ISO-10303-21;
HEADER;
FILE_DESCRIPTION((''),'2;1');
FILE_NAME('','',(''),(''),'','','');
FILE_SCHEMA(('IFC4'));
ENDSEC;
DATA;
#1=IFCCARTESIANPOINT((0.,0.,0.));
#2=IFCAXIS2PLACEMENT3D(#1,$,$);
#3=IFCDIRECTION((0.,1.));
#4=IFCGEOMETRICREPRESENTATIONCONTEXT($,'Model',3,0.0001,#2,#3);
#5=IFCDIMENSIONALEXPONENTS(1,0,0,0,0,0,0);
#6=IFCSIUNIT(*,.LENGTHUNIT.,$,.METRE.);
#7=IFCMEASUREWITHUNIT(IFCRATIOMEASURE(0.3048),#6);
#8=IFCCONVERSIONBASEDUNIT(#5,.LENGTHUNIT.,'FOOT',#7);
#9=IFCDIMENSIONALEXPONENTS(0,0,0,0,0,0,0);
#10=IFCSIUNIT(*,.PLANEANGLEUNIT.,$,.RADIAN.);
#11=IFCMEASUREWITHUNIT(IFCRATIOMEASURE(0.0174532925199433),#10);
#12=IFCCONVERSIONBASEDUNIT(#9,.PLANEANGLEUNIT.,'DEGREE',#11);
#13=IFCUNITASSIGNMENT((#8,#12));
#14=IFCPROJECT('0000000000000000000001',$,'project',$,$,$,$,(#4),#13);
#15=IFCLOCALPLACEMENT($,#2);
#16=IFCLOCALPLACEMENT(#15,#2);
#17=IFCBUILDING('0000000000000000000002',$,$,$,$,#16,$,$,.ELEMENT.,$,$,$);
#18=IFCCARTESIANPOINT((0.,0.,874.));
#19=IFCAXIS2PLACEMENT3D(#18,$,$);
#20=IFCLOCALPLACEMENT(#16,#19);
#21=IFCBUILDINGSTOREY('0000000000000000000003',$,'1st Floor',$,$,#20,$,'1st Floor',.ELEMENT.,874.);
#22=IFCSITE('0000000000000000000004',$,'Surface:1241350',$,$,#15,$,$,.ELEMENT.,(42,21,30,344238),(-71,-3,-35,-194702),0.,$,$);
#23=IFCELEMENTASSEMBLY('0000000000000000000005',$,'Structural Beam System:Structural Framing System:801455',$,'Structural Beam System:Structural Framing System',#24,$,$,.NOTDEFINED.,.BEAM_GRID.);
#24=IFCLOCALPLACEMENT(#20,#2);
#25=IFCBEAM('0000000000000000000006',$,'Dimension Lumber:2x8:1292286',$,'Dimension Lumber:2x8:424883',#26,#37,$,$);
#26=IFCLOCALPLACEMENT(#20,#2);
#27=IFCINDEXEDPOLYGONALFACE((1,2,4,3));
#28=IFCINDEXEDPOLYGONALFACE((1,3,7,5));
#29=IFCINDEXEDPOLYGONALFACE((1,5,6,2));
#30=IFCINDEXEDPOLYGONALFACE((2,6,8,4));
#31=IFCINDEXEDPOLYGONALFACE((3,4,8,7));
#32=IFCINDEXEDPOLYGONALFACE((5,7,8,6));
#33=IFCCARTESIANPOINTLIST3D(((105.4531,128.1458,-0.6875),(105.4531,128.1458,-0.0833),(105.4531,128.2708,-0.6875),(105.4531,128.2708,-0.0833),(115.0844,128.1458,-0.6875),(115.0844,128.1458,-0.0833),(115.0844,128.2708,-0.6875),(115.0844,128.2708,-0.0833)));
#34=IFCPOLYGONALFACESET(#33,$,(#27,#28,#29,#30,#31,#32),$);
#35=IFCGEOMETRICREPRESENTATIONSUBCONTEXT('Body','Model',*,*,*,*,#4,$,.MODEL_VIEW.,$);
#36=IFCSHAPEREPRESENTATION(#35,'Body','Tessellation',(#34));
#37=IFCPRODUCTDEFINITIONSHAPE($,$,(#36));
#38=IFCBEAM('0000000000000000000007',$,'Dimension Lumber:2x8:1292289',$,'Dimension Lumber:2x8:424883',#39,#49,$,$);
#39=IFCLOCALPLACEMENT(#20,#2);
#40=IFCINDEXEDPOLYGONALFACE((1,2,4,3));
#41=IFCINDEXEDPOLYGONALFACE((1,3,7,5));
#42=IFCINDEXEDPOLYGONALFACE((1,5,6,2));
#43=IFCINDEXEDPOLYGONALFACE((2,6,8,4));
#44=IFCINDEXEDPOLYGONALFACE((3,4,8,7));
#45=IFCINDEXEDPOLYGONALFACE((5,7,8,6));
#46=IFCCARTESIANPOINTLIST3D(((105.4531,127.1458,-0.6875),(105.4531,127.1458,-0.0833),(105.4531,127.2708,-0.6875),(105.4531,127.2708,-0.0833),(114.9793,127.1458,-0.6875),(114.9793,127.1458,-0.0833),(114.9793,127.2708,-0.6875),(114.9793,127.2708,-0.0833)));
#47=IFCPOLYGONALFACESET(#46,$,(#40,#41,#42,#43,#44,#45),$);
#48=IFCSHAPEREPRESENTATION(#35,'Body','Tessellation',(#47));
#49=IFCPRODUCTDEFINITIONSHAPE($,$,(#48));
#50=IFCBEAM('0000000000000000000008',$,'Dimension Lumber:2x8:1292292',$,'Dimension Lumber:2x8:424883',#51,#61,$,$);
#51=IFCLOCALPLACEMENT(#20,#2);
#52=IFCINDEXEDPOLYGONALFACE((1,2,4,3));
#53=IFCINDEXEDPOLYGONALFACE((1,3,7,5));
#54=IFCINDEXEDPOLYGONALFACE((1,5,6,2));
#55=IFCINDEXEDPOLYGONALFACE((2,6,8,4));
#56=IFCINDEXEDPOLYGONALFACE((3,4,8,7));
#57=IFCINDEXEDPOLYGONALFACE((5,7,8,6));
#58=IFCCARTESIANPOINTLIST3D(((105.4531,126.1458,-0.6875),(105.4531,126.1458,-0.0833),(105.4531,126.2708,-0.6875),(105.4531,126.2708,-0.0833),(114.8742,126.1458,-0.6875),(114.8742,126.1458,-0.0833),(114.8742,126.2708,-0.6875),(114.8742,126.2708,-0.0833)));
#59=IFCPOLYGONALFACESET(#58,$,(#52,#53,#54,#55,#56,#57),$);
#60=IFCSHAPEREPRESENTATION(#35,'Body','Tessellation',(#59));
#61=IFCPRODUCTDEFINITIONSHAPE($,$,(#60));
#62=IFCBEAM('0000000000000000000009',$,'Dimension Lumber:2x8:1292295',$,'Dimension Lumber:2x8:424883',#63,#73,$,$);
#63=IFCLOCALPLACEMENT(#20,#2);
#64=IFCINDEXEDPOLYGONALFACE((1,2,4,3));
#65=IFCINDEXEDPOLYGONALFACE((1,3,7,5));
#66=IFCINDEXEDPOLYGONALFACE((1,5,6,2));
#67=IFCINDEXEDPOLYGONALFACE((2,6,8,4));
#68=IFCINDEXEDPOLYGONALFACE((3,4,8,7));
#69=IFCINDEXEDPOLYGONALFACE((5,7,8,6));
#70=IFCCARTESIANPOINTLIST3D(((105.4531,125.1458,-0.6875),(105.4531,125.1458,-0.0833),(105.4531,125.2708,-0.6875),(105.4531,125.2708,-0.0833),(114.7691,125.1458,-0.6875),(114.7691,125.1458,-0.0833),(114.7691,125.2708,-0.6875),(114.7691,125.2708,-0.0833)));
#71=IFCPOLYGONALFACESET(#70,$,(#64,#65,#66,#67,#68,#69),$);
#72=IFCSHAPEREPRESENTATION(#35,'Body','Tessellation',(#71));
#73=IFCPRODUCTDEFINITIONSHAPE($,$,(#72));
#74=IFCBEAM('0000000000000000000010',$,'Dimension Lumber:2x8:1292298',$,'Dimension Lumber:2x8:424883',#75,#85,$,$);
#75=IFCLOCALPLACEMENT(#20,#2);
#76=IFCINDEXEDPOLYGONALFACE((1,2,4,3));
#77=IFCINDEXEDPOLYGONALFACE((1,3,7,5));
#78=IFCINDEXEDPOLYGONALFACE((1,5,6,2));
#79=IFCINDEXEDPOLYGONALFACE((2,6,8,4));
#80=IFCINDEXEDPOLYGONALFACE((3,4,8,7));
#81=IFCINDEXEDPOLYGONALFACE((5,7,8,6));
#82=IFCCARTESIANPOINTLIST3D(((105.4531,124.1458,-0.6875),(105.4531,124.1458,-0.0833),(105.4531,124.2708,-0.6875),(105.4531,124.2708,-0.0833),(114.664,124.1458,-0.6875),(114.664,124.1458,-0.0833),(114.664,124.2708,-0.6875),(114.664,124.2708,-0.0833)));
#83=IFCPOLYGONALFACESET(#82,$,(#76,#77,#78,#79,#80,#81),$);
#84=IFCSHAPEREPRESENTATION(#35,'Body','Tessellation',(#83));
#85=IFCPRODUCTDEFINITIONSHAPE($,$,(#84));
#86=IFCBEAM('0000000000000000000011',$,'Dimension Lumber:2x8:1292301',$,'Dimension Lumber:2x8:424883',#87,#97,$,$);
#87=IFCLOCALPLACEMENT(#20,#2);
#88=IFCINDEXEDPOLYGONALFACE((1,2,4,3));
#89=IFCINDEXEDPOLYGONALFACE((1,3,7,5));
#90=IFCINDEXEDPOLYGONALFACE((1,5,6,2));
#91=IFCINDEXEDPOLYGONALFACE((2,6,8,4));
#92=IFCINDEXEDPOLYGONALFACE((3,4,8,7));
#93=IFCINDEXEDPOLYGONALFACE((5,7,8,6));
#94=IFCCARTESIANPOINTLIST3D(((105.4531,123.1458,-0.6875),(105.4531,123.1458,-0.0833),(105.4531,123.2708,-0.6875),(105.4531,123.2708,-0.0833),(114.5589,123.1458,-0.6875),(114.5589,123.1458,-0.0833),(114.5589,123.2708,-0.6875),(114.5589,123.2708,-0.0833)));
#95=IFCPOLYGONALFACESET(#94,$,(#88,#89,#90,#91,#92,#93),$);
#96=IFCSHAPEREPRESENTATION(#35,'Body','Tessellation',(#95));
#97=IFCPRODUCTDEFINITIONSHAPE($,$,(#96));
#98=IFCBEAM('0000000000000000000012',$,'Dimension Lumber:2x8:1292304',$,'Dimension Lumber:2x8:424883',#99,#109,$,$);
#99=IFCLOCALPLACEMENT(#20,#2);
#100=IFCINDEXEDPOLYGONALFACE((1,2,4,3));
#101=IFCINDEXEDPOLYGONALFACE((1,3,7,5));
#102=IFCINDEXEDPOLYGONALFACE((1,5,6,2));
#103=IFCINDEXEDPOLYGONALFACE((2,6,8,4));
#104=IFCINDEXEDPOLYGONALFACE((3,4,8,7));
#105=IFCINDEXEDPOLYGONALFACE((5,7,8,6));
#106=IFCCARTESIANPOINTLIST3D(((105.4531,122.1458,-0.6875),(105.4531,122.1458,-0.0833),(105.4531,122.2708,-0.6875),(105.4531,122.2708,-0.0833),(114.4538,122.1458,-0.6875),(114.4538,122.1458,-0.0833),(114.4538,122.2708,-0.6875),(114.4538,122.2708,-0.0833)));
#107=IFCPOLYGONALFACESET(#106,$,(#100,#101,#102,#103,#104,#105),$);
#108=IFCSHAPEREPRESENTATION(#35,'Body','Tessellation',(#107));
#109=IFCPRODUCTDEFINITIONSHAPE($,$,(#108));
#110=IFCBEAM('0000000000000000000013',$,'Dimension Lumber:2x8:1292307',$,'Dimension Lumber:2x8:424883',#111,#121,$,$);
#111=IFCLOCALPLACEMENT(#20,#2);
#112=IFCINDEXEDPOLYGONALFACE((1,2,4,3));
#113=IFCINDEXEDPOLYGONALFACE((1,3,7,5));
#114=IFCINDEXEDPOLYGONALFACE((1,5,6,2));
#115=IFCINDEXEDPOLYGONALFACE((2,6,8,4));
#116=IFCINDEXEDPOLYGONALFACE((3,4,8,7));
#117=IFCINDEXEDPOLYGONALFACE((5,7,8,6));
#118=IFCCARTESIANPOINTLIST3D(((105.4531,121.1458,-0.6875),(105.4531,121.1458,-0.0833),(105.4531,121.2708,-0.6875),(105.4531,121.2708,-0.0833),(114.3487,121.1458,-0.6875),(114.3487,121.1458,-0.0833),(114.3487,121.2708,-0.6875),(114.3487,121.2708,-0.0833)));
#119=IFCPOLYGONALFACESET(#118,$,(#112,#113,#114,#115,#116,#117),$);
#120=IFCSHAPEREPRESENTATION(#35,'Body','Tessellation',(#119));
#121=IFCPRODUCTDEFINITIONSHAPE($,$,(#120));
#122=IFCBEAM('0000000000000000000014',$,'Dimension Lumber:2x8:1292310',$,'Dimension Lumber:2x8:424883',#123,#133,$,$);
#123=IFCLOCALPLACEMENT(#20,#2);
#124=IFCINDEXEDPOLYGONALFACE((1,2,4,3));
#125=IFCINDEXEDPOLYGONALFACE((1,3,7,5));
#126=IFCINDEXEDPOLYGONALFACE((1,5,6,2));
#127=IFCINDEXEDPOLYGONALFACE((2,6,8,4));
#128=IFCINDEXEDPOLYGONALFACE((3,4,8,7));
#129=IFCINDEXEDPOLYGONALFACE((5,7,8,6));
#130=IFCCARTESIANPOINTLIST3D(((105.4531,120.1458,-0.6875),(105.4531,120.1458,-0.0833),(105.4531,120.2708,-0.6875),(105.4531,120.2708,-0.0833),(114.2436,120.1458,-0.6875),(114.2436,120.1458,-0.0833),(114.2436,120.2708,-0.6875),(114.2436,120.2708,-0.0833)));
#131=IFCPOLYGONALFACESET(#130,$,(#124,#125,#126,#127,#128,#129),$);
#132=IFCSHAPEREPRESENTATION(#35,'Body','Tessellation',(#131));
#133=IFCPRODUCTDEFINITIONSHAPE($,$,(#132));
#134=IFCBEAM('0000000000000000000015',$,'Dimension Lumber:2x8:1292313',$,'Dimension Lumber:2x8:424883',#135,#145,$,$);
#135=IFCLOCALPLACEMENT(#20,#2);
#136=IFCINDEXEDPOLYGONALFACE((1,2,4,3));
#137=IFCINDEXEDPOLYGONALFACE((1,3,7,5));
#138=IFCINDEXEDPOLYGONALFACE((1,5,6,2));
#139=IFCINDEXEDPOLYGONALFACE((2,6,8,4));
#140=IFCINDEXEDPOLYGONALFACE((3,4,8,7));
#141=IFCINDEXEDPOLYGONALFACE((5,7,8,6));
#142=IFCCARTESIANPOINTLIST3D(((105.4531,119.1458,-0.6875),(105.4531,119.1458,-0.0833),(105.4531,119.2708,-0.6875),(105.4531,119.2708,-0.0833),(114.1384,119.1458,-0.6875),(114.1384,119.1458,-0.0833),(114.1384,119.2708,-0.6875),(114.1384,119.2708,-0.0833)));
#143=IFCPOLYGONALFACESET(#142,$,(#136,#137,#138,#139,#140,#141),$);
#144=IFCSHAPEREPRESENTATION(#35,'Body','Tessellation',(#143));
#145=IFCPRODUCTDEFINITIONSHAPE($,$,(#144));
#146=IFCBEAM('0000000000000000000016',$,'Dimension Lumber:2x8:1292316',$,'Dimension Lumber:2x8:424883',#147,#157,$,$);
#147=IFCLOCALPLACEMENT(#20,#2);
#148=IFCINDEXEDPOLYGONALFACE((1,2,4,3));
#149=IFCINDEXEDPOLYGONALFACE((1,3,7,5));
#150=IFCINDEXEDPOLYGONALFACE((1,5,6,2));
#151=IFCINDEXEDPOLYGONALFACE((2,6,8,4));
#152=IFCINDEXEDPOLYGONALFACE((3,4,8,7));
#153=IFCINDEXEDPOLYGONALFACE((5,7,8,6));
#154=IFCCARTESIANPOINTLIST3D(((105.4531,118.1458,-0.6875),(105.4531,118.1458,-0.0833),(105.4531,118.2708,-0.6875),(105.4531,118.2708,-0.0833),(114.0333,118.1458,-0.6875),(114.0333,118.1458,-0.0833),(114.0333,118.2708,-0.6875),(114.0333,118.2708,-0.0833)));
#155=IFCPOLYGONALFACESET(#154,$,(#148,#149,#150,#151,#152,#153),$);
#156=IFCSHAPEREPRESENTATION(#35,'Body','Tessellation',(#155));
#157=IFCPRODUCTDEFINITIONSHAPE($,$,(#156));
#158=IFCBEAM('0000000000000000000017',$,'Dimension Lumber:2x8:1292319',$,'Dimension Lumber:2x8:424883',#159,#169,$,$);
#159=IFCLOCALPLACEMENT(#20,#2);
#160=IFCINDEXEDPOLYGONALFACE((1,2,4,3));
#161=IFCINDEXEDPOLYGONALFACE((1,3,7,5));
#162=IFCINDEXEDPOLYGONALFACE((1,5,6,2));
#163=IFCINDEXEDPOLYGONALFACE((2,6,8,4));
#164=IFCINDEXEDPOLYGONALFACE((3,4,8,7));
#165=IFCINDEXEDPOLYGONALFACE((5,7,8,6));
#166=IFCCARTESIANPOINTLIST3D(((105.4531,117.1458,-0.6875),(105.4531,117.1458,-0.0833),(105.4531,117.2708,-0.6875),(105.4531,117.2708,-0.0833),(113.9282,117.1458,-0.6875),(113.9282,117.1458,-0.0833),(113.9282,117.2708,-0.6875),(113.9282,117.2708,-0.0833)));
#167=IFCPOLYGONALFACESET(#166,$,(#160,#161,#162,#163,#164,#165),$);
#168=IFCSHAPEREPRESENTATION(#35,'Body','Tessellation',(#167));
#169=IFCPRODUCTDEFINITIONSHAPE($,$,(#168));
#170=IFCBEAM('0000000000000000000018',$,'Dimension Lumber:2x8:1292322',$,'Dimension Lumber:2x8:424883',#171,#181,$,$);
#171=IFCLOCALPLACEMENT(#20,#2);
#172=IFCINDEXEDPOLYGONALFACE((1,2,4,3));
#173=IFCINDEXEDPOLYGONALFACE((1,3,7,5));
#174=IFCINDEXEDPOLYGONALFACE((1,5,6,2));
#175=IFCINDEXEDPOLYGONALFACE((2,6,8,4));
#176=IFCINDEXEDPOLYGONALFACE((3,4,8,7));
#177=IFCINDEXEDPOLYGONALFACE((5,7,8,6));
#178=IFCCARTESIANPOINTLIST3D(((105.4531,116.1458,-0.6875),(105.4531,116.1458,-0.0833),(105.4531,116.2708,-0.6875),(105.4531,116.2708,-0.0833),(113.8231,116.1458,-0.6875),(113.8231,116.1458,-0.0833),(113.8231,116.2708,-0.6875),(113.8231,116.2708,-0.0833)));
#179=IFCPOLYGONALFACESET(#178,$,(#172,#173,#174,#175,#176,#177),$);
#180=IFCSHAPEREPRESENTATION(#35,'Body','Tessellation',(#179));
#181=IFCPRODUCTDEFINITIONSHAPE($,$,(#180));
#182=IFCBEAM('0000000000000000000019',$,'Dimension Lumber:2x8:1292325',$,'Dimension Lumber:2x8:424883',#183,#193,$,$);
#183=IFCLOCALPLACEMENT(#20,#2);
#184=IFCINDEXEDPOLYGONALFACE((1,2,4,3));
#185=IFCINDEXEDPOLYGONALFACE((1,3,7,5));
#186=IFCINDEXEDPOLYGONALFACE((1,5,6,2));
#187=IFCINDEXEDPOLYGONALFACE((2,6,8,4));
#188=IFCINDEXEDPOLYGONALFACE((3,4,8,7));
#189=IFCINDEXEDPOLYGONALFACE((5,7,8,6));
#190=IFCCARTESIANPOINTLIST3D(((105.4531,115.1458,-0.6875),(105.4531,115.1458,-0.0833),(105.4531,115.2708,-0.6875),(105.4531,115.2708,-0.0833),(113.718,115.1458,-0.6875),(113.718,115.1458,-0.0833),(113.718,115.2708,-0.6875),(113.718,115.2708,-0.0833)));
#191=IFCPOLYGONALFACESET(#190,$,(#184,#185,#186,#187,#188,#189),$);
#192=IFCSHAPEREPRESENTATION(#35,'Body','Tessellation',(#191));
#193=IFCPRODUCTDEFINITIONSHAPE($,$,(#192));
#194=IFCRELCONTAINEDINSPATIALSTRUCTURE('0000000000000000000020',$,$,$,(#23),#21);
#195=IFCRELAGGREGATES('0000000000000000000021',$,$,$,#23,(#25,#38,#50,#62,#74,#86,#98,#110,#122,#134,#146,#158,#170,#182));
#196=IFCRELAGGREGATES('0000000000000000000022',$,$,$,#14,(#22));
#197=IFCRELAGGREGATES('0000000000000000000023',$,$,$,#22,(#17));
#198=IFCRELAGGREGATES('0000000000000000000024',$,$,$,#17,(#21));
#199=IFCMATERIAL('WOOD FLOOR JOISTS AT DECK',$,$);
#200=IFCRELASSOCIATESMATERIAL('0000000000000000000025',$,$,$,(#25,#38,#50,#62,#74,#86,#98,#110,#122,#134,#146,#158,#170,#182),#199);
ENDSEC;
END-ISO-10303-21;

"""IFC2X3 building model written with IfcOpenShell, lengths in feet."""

from ifc_helpers import new_model, entity, si_unit, converted_unit, direction, frame, frame_2d, origin, origin_2d_with_axis, place, context, subcontext, project, spatial, rectangle, extrude, material, element, aggregate, save


model = new_model("IFC2X3")

# Units and contexts
model_context = context("Model", 3, precision=0.0001, world=origin(), true_north=direction((0.0, 1.0)))
body_context = subcontext(model_context, "Body", "Model", "MODEL_VIEW")
ifc_project = project(units=[converted_unit("LENGTHUNIT", "FOOT", entity("IfcRatioMeasure", 0.3048), si_unit("LENGTHUNIT", "METRE"), dimensions=[1, 0, 0, 0, 0, 0, 0]), converted_unit("PLANEANGLEUNIT", "DEGREE", entity("IfcRatioMeasure", 0.0174532925199433), si_unit("PLANEANGLEUNIT", "RADIAN"), dimensions=[0, 0, 0, 0, 0, 0, 0])], contexts=[model_context])

# Site, building, storey
site_placement = place(None, origin())
site = spatial("IfcSite", under=ifc_project, at=site_placement, Name="Surface:1241350", CompositionType="ELEMENT", RefLatitude=(42, 21, 30, 344238), RefLongitude=(-71, -3, -35, -194702), RefElevation=0.0)
building_placement = place(site_placement, origin())
building = spatial("IfcBuilding", under=site, at=building_placement, CompositionType="ELEMENT")
storey_placement = place(building_placement, frame((0.0, 0.0, 874.0)))
storey = spatial("IfcBuildingStorey", under=building, at=storey_placement, Name="1st Floor", LongName="1st Floor", CompositionType="ELEMENT", Elevation=874.0)

# Element assembly, beams
assembly_placement = place(storey_placement, origin())
assembly = element("IfcElementAssembly", 1, at=assembly_placement, inside=storey, Name="Structural Beam System:Structural Framing System:801455", ObjectType="Structural Beam System:Structural Framing System", AssemblyPlace="NOTDEFINED", PredefinedType="BEAM_GRID")
ifc_material_1 = material(Name="WOOD FLOOR JOISTS AT DECK")
beam_1_placement = place(assembly_placement, frame((105.3906, 128.2083, 0.0)))
beam_1 = element("IfcBeam", 2, at=beam_1_placement, material=ifc_material_1, Name="Dimension Lumber:2x8:1292286", ObjectType="Dimension Lumber:2x8:424883", context=body_context, shape_type="SweptSolid", body=[
    extrude(rectangle(XDim=0.6042, YDim=0.125, at=origin_2d_with_axis()), frame((0.0625, 0.0, -0.3854), z_axis=(1.0, 0.0, 0.0), x_axis=(0.0, 0.0, -1.0)), (0.0, 0.0, 1.0), 9.6313),
])
beam_2_placement = place(assembly_placement, frame((105.3906, 127.2083, 0.0)))
beam_2 = element("IfcBeam", 3, at=beam_2_placement, material=ifc_material_1, Name="Dimension Lumber:2x8:1292289", ObjectType="Dimension Lumber:2x8:424883", context=body_context, shape_type="SweptSolid", body=[
    extrude(rectangle(XDim=0.6042, YDim=0.125, at=origin_2d_with_axis()), frame((0.0625, 0.0, -0.3854), z_axis=(1.0, 0.0, 0.0), x_axis=(0.0, 0.0, -1.0)), (0.0, 0.0, 1.0), 9.5262),
])
beam_3_placement = place(assembly_placement, frame((105.3906, 126.2083, 0.0)))
beam_3 = element("IfcBeam", 4, at=beam_3_placement, material=ifc_material_1, Name="Dimension Lumber:2x8:1292292", ObjectType="Dimension Lumber:2x8:424883", context=body_context, shape_type="SweptSolid", body=[
    extrude(rectangle(XDim=0.6042, YDim=0.125, at=origin_2d_with_axis()), frame((0.0625, 0.0, -0.3854), z_axis=(1.0, 0.0, 0.0), x_axis=(0.0, 0.0, -1.0)), (0.0, 0.0, 1.0), 9.4211),
])
beam_4_placement = place(assembly_placement, frame((105.3906, 125.2083, 0.0)))
beam_4 = element("IfcBeam", 5, at=beam_4_placement, material=ifc_material_1, Name="Dimension Lumber:2x8:1292295", ObjectType="Dimension Lumber:2x8:424883", context=body_context, shape_type="SweptSolid", body=[
    extrude(rectangle(XDim=0.6042, YDim=0.125, at=origin_2d_with_axis()), frame((0.0625, 0.0, -0.3854), z_axis=(1.0, 0.0, 0.0), x_axis=(0.0, 0.0, -1.0)), (0.0, 0.0, 1.0), 9.316),
])
beam_5_placement = place(assembly_placement, frame((105.3906, 124.2083, 0.0)))
beam_5 = element("IfcBeam", 6, at=beam_5_placement, material=ifc_material_1, Name="Dimension Lumber:2x8:1292298", ObjectType="Dimension Lumber:2x8:424883", context=body_context, shape_type="SweptSolid", body=[
    extrude(rectangle(XDim=0.6042, YDim=0.125, at=origin_2d_with_axis()), frame((0.0625, 0.0, -0.3854), z_axis=(1.0, 0.0, 0.0), x_axis=(0.0, 0.0, -1.0)), (0.0, 0.0, 1.0), 9.2109),
])
beam_6_placement = place(assembly_placement, frame((105.3906, 123.2083, 0.0)))
beam_6 = element("IfcBeam", 7, at=beam_6_placement, material=ifc_material_1, Name="Dimension Lumber:2x8:1292301", ObjectType="Dimension Lumber:2x8:424883", context=body_context, shape_type="SweptSolid", body=[
    extrude(rectangle(XDim=0.6042, YDim=0.125, at=origin_2d_with_axis()), frame((0.0625, 0.0, -0.3854), z_axis=(1.0, 0.0, 0.0), x_axis=(0.0, 0.0, -1.0)), (0.0, 0.0, 1.0), 9.1058),
])
beam_7_placement = place(assembly_placement, frame((105.3906, 122.2083, 0.0)))
beam_7 = element("IfcBeam", 8, at=beam_7_placement, material=ifc_material_1, Name="Dimension Lumber:2x8:1292304", ObjectType="Dimension Lumber:2x8:424883", context=body_context, shape_type="SweptSolid", body=[
    extrude(rectangle(XDim=0.6042, YDim=0.125, at=origin_2d_with_axis()), frame((0.0625, 0.0, -0.3854), z_axis=(1.0, 0.0, 0.0), x_axis=(0.0, 0.0, -1.0)), (0.0, 0.0, 1.0), 9.0006),
])
beam_8_placement = place(assembly_placement, frame((105.3906, 121.2083, 0.0)))
beam_8 = element("IfcBeam", 9, at=beam_8_placement, material=ifc_material_1, Name="Dimension Lumber:2x8:1292307", ObjectType="Dimension Lumber:2x8:424883", context=body_context, shape_type="SweptSolid", body=[
    extrude(rectangle(XDim=0.6042, YDim=0.125, at=origin_2d_with_axis()), frame((0.0625, 0.0, -0.3854), z_axis=(1.0, 0.0, 0.0), x_axis=(0.0, 0.0, -1.0)), (0.0, 0.0, 1.0), 8.8955),
])
beam_9_placement = place(assembly_placement, frame((105.3906, 120.2083, 0.0)))
beam_9 = element("IfcBeam", 10, at=beam_9_placement, material=ifc_material_1, Name="Dimension Lumber:2x8:1292310", ObjectType="Dimension Lumber:2x8:424883", context=body_context, shape_type="SweptSolid", body=[
    extrude(rectangle(XDim=0.6042, YDim=0.125, at=origin_2d_with_axis()), frame((0.0625, 0.0, -0.3854), z_axis=(1.0, 0.0, 0.0), x_axis=(0.0, 0.0, -1.0)), (0.0, 0.0, 1.0), 8.7904),
])
beam_10_placement = place(assembly_placement, frame((105.4531, 119.2083, 0.0)))
beam_10 = element("IfcBeam", 11, at=beam_10_placement, material=ifc_material_1, Name="Dimension Lumber:2x8:1292313", ObjectType="Dimension Lumber:2x8:424883", context=body_context, shape_type="SweptSolid", body=[
    extrude(rectangle(XDim=0.6042, YDim=0.125, at=frame_2d((0.0, 0.0), x_axis=(1.0, 0.0))), frame((0.0, 0.0, -0.3854), z_axis=(1.0, 0.0, 0.0), x_axis=(0.0, 0.0, -1.0)), (0.0, 0.0, 1.0), 8.6853),
])
beam_11_placement = place(assembly_placement, frame((105.3906, 118.2083, 0.0)))
beam_11 = element("IfcBeam", 12, at=beam_11_placement, material=ifc_material_1, Name="Dimension Lumber:2x8:1292316", ObjectType="Dimension Lumber:2x8:424883", context=body_context, shape_type="SweptSolid", body=[
    extrude(rectangle(XDim=0.6042, YDim=0.125, at=origin_2d_with_axis()), frame((0.0625, 0.0, -0.3854), z_axis=(1.0, 0.0, 0.0), x_axis=(0.0, 0.0, -1.0)), (0.0, 0.0, 1.0), 8.5802),
])
beam_12_placement = place(assembly_placement, frame((105.3906, 117.2083, 0.0)))
beam_12 = element("IfcBeam", 13, at=beam_12_placement, material=ifc_material_1, Name="Dimension Lumber:2x8:1292319", ObjectType="Dimension Lumber:2x8:424883", context=body_context, shape_type="SweptSolid", body=[
    extrude(rectangle(XDim=0.6042, YDim=0.125, at=origin_2d_with_axis()), frame((0.0625, 0.0, -0.3854), z_axis=(1.0, 0.0, 0.0), x_axis=(0.0, 0.0, -1.0)), (0.0, 0.0, 1.0), 8.4751),
])
beam_13_placement = place(assembly_placement, frame((105.3906, 116.2083, 0.0)))
beam_13 = element("IfcBeam", 14, at=beam_13_placement, material=ifc_material_1, Name="Dimension Lumber:2x8:1292322", ObjectType="Dimension Lumber:2x8:424883", context=body_context, shape_type="SweptSolid", body=[
    extrude(rectangle(XDim=0.6042, YDim=0.125, at=origin_2d_with_axis()), frame((0.0625, 0.0, -0.3854), z_axis=(1.0, 0.0, 0.0), x_axis=(0.0, 0.0, -1.0)), (0.0, 0.0, 1.0), 8.37),
])
beam_14_placement = place(assembly_placement, frame((105.3906, 115.2083, 0.0)))
beam_14 = element("IfcBeam", 15, at=beam_14_placement, material=ifc_material_1, Name="Dimension Lumber:2x8:1292325", ObjectType="Dimension Lumber:2x8:424883", context=body_context, shape_type="SweptSolid", body=[
    extrude(rectangle(XDim=0.6042, YDim=0.125, at=origin_2d_with_axis()), frame((0.0625, 0.0, -0.3854), z_axis=(1.0, 0.0, 0.0), x_axis=(0.0, 0.0, -1.0)), (0.0, 0.0, 1.0), 8.2649),
])
aggregate(assembly, [beam_1, beam_2, beam_3, beam_4, beam_5, beam_6, beam_7, beam_8, beam_9, beam_10, beam_11, beam_12, beam_13, beam_14])

save(model, "model.ifc")
